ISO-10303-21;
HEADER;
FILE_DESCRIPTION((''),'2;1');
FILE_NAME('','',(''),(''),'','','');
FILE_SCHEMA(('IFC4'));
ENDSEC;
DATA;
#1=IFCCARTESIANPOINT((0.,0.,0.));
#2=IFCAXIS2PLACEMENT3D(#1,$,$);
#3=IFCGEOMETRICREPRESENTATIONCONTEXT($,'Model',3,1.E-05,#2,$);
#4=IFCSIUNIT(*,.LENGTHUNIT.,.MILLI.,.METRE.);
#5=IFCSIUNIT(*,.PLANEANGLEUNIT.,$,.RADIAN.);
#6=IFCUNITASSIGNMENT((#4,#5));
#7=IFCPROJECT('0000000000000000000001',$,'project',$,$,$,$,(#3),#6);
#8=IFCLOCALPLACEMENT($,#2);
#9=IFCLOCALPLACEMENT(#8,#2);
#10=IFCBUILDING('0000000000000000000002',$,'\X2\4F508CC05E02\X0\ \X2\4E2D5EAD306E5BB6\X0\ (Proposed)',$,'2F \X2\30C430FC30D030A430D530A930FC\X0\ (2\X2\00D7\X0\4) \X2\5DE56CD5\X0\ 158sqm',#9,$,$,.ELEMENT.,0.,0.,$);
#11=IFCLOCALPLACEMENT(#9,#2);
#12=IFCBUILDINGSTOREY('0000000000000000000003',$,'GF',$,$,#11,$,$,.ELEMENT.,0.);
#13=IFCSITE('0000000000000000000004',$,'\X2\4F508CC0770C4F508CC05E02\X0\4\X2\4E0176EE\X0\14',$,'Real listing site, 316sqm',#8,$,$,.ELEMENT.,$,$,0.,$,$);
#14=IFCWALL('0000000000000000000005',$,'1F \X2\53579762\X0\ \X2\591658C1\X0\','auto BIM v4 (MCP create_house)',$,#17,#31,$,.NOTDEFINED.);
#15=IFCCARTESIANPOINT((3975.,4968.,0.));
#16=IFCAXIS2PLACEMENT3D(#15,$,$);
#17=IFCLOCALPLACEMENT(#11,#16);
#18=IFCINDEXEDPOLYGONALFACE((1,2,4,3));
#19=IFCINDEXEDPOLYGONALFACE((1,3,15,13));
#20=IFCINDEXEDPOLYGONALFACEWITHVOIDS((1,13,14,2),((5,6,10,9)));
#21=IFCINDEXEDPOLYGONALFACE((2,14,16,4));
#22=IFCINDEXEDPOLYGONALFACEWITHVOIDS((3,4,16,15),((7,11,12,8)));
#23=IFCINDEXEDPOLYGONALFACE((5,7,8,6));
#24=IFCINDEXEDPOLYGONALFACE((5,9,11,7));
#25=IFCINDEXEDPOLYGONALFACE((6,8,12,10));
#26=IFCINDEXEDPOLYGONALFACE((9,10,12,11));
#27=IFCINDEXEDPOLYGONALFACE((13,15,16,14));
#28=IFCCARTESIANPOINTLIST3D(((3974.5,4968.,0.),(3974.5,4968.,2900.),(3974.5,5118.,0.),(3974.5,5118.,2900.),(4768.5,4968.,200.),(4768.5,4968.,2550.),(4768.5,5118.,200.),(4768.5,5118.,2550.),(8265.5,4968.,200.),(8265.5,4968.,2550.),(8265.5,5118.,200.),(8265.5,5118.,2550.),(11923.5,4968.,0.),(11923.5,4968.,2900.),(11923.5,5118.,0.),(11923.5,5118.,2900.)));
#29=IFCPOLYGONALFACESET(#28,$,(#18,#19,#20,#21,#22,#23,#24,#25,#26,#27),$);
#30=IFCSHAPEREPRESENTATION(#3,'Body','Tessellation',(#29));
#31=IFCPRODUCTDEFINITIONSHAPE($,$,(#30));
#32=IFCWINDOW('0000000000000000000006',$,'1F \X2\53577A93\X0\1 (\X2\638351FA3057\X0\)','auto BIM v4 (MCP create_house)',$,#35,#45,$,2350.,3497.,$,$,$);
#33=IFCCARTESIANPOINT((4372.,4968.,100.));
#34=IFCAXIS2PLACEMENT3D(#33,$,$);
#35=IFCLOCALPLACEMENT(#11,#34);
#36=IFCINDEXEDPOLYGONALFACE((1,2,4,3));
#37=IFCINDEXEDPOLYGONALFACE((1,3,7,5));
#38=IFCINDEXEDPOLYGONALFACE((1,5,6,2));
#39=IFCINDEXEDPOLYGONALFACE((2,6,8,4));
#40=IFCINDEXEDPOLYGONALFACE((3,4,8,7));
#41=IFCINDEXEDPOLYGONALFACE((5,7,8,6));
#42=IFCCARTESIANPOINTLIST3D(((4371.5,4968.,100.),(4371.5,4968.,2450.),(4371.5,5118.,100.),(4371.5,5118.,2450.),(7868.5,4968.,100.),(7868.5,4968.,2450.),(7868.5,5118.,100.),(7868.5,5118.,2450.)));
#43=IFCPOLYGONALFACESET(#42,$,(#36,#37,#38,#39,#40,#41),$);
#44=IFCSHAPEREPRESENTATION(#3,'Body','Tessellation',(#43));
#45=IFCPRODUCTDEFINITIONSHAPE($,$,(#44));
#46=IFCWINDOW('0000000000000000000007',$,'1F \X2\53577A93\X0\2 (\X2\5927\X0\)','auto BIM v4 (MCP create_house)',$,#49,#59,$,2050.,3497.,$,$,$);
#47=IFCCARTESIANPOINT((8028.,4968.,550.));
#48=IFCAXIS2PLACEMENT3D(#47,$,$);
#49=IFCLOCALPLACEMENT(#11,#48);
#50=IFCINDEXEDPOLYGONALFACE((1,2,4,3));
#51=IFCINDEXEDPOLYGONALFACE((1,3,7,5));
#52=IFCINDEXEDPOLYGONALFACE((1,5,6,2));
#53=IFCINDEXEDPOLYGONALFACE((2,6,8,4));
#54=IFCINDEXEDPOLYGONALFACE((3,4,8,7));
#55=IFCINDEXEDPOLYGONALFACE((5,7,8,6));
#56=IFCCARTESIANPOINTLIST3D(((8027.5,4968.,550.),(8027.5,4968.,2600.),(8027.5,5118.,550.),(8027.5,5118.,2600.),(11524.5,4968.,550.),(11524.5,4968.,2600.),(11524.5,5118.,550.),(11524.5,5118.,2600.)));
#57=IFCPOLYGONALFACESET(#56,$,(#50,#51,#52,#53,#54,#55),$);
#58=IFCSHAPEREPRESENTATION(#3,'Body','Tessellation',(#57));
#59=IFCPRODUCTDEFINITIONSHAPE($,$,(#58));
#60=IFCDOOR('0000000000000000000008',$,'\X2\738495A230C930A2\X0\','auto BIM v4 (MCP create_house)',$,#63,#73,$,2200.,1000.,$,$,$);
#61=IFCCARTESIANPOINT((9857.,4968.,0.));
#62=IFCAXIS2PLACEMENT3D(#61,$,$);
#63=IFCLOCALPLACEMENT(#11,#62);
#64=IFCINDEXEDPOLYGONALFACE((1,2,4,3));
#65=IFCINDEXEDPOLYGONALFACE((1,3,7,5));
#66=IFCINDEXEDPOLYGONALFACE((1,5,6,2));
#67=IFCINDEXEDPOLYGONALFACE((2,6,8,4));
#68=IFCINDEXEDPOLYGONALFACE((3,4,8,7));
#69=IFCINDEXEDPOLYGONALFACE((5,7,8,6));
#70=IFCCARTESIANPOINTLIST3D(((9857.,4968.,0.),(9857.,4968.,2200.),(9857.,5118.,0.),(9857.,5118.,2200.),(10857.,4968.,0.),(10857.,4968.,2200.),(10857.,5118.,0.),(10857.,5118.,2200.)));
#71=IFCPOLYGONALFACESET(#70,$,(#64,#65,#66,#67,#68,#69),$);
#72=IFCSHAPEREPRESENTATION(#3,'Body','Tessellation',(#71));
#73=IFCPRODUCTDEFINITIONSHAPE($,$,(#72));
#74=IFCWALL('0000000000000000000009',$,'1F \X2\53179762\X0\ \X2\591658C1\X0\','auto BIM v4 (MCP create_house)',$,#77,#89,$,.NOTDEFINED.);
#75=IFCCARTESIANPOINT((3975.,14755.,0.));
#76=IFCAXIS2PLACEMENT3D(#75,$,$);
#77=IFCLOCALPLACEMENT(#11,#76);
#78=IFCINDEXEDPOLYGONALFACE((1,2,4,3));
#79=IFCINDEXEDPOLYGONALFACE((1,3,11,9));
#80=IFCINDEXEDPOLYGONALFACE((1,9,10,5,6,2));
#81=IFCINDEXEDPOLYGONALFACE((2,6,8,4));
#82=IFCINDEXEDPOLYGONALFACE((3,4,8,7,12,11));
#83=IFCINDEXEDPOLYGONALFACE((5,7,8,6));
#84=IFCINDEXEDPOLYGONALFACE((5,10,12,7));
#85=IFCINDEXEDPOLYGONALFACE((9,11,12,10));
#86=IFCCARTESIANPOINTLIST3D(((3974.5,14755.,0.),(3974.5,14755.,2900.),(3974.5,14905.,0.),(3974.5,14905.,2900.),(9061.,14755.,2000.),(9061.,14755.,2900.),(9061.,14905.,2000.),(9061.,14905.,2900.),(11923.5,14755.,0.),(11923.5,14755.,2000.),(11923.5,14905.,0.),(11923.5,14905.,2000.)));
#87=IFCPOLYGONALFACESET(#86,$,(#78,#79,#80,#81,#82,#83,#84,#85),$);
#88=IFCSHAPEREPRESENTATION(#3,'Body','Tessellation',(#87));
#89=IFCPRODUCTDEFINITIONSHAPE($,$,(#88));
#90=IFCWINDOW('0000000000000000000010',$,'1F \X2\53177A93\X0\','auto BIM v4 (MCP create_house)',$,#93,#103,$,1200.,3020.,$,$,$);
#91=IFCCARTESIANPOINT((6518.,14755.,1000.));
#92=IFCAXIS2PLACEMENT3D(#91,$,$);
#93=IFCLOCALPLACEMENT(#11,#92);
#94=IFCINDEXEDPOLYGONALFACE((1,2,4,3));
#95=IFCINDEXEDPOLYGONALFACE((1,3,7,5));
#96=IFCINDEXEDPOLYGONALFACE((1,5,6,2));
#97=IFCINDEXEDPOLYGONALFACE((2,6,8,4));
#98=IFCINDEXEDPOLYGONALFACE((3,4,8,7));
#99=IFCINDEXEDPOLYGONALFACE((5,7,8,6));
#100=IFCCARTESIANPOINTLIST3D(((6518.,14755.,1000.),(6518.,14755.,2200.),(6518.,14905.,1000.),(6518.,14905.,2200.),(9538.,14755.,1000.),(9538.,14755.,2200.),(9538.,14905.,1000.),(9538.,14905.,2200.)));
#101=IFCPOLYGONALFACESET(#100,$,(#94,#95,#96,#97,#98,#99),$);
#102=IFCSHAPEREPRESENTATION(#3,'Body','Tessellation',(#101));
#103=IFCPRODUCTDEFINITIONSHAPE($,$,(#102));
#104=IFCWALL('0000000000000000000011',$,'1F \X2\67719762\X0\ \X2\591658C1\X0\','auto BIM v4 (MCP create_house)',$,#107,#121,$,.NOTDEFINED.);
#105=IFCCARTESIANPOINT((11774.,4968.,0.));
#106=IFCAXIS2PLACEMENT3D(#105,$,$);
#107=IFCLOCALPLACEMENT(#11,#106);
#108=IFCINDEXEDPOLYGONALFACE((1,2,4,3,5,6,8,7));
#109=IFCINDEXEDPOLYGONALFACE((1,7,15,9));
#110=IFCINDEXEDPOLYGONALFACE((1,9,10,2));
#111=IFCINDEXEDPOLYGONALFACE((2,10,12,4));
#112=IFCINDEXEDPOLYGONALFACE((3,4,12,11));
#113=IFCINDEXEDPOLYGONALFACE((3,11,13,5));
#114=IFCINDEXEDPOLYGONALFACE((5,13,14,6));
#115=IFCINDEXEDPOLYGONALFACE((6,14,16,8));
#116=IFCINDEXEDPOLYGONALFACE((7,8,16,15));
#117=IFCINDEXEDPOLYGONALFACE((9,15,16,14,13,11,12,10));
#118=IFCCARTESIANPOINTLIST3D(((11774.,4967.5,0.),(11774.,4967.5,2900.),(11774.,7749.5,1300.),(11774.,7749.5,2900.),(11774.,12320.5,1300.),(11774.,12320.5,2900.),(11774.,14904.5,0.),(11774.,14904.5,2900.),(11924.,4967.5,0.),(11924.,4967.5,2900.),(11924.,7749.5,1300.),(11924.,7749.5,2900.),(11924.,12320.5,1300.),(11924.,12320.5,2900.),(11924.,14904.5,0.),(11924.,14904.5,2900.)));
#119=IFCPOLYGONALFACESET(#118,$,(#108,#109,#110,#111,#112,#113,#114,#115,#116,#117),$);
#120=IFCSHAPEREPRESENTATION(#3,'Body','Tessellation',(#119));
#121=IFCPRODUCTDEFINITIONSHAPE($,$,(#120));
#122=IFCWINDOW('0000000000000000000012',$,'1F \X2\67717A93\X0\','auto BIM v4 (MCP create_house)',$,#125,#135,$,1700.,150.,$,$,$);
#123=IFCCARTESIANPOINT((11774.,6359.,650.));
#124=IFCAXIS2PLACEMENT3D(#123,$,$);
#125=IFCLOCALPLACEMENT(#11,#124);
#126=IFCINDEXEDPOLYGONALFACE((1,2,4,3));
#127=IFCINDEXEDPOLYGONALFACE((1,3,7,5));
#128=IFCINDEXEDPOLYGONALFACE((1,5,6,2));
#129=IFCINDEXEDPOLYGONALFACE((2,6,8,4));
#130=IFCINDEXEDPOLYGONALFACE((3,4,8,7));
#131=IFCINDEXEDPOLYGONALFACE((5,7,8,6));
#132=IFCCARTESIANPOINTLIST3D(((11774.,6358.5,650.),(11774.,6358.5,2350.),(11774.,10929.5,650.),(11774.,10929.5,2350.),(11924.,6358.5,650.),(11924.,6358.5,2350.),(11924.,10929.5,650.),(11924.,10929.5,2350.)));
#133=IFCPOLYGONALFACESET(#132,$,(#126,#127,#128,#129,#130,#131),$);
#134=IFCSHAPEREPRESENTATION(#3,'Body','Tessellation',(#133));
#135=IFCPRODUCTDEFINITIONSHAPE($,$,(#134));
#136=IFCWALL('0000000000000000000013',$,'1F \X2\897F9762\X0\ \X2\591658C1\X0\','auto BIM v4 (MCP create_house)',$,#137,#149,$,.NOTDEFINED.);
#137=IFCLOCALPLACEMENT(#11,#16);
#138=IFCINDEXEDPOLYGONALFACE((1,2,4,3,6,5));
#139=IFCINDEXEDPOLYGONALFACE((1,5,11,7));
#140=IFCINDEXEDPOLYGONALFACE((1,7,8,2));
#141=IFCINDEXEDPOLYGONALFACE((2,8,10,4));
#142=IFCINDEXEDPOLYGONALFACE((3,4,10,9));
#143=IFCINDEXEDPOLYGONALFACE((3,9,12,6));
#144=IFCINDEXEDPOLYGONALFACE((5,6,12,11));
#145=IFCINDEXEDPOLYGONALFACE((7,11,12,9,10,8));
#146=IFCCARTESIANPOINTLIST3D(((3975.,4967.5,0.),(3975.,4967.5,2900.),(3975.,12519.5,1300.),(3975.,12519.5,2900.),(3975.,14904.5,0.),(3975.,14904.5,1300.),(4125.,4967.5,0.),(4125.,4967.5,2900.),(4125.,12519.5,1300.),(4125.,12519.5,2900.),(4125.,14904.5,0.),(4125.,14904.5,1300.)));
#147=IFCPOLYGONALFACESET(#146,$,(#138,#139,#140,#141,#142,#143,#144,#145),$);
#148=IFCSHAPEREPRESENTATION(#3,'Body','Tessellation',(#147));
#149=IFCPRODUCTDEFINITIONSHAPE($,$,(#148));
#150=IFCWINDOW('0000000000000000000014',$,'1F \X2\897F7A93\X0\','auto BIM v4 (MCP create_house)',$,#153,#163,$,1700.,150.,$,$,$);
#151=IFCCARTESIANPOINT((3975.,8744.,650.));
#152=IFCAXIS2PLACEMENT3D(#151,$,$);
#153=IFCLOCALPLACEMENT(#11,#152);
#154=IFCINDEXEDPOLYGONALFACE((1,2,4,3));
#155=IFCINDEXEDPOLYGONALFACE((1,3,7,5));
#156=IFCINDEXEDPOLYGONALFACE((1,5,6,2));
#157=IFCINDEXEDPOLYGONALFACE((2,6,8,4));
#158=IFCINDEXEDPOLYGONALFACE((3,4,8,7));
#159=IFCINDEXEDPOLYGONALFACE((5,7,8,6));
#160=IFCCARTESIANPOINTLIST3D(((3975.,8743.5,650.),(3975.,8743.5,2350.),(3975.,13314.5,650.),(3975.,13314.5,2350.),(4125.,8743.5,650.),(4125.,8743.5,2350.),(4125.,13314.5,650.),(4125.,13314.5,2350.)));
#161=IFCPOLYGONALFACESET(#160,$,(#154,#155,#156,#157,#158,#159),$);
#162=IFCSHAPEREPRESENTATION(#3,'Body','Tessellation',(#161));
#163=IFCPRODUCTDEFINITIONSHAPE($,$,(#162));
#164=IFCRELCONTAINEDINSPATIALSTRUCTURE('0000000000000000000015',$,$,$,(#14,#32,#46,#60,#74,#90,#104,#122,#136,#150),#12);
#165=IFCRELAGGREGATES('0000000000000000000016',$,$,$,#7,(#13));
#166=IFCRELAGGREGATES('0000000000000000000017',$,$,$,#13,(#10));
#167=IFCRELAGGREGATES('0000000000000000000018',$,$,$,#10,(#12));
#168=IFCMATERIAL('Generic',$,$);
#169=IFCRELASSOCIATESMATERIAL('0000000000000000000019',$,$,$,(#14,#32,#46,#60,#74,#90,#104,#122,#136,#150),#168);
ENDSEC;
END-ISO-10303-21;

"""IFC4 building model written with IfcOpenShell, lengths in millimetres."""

from ifc_helpers import new_model, si_unit, frame, frame_2d, origin, place, context, project, spatial, rectangle, extrude, material, element, fill, save


model = new_model("IFC4")

# Units and contexts
model_context = context("Model", 3, precision=1e-05, world=origin())
ifc_project = project(units=[si_unit("LENGTHUNIT", "METRE", prefix="MILLI"), si_unit("PLANEANGLEUNIT", "RADIAN")], contexts=[model_context])

# Site, building, storey
site_placement = place(None, origin())
site = spatial("IfcSite", under=ifc_project, at=site_placement, Name="佐賀県佐賀市4丁目14", ObjectType="Real listing site, 316sqm", CompositionType="ELEMENT", RefElevation=0.0)
building_placement = place(site_placement, origin())
building = spatial("IfcBuilding", under=site, at=building_placement, Name="佐賀市 中庭の家 (Proposed)", ObjectType="2F ツーバイフォー (2×4) 工法 158sqm", CompositionType="ELEMENT", ElevationOfRefHeight=0.0, ElevationOfTerrain=0.0)
storey_placement = place(building_placement, origin())
storey = spatial("IfcBuildingStorey", under=building, at=storey_placement, Name="GF", CompositionType="ELEMENT", Elevation=0.0)

# Shared definitions
ifc_material = material(Name="Generic")

# Wall, openings, windows, door
wall_1_placement = place(storey_placement, frame((3975.0, 4968.0, 0.0)))
wall_1 = element("IfcWall", 1, at=wall_1_placement, inside=storey, material=ifc_material, Name="1F 南面 外壁", Description="auto BIM v4 (MCP create_house)", PredefinedType="NOTDEFINED", context=model_context, shape_type="SweptSolid", body=[
    extrude(rectangle(XDim=7949.0, YDim=150.0, at=frame_2d((3974.0, 75.0))), frame((3975.0, 4968.0, 0.0)), (0.0, 0.0, 1.0), 2900.0),
])
opening_1_placement = place(storey_placement, frame((4372.0, 4968.0, 100.0)))
opening_1 = element("IfcOpeningElement", 2, at=opening_1_placement, cuts=wall_1, PredefinedType="NOTDEFINED", context=model_context, shape_type="SweptSolid", body=[
    extrude(rectangle(XDim=3497.0, YDim=150.0, at=frame_2d((1748.0, 75.0))), frame((4372.0, 4968.0, 100.0)), (0.0, 0.0, 1.0), 2350.0),
])
opening_2_placement = place(storey_placement, frame((8028.0, 4968.0, 550.0)))
opening_2 = element("IfcOpeningElement", 3, at=opening_2_placement, cuts=wall_1, PredefinedType="NOTDEFINED", context=model_context, shape_type="SweptSolid", body=[
    extrude(rectangle(XDim=3497.0, YDim=150.0, at=frame_2d((1748.0, 75.0))), frame((8028.0, 4968.0, 550.0)), (0.0, 0.0, 1.0), 2050.0),
])
opening_3_placement = place(storey_placement, frame((9857.0, 4968.0, 0.0)))
opening_3 = element("IfcOpeningElement", 4, at=opening_3_placement, cuts=wall_1, PredefinedType="NOTDEFINED", context=model_context, shape_type="SweptSolid", body=[
    extrude(rectangle(XDim=1000.0, YDim=150.0, at=frame_2d((500.0, 75.0))), frame((9857.0, 4968.0, 0.0)), (0.0, 0.0, 1.0), 2200.0),
])
window_1_placement = place(storey_placement, frame((4372.0, 4968.0, 100.0)))
window_1 = element("IfcWindow", 5, at=window_1_placement, inside=storey, material=ifc_material, Name="1F 南窓1 (掃出し)", Description="auto BIM v4 (MCP create_house)", OverallHeight=2350.0, OverallWidth=3497.0, context=model_context, shape_type="SweptSolid", body=[
    extrude(rectangle(XDim=3497.0, YDim=150.0, at=frame_2d((1748.0, 75.0))), frame((4372.0, 4968.0, 100.0)), (0.0, 0.0, 1.0), 2350.0),
])
fill(opening_1, window_1)
window_2_placement = place(storey_placement, frame((8028.0, 4968.0, 550.0)))
window_2 = element("IfcWindow", 6, at=window_2_placement, inside=storey, material=ifc_material, Name="1F 南窓2 (大)", Description="auto BIM v4 (MCP create_house)", OverallHeight=2050.0, OverallWidth=3497.0, context=model_context, shape_type="SweptSolid", body=[
    extrude(rectangle(XDim=3497.0, YDim=150.0, at=frame_2d((1748.0, 75.0))), frame((8028.0, 4968.0, 550.0)), (0.0, 0.0, 1.0), 2050.0),
])
fill(opening_2, window_2)
door_1_placement = place(storey_placement, frame((9857.0, 4968.0, 0.0)))
door_1 = element("IfcDoor", 7, at=door_1_placement, inside=storey, material=ifc_material, Name="玄関ドア", Description="auto BIM v4 (MCP create_house)", OverallHeight=2200.0, OverallWidth=1000.0, context=model_context, shape_type="SweptSolid", body=[
    extrude(rectangle(XDim=1000.0, YDim=150.0, at=frame_2d((500.0, 75.0))), frame((9857.0, 4968.0, 0.0)), (0.0, 0.0, 1.0), 2200.0),
])
fill(opening_3, door_1)

# Walls, openings, windows
wall_2_placement = place(storey_placement, frame((3975.0, 14755.0, 0.0)))
wall_2 = element("IfcWall", 8, at=wall_2_placement, inside=storey, material=ifc_material, Name="1F 北面 外壁", Description="auto BIM v4 (MCP create_house)", PredefinedType="NOTDEFINED", context=model_context, shape_type="SweptSolid", body=[
    extrude(rectangle(XDim=7949.0, YDim=150.0, at=frame_2d((3974.0, 75.0))), frame((3975.0, 14755.0, 0.0)), (0.0, 0.0, 1.0), 2900.0),
])
opening_4_placement = place(storey_placement, frame((6518.0, 14755.0, 1000.0)))
opening_4 = element("IfcOpeningElement", 9, at=opening_4_placement, cuts=wall_2, PredefinedType="NOTDEFINED", context=model_context, shape_type="SweptSolid", body=[
    extrude(rectangle(XDim=3020.0, YDim=150.0, at=frame_2d((1510.0, 75.0))), frame((6518.0, 14755.0, 1000.0)), (0.0, 0.0, 1.0), 1200.0),
])
window_3_placement = place(storey_placement, frame((6518.0, 14755.0, 1000.0)))
window_3 = element("IfcWindow", 10, at=window_3_placement, inside=storey, material=ifc_material, Name="1F 北窓", Description="auto BIM v4 (MCP create_house)", OverallHeight=1200.0, OverallWidth=3020.0, context=model_context, shape_type="SweptSolid", body=[
    extrude(rectangle(XDim=3020.0, YDim=150.0, at=frame_2d((1510.0, 75.0))), frame((6518.0, 14755.0, 1000.0)), (0.0, 0.0, 1.0), 1200.0),
])
fill(opening_4, window_3)
wall_3_placement = place(storey_placement, frame((11774.0, 4968.0, 0.0)))
wall_3 = element("IfcWall", 11, at=wall_3_placement, inside=storey, material=ifc_material, Name="1F 東面 外壁", Description="auto BIM v4 (MCP create_house)", PredefinedType="NOTDEFINED", context=model_context, shape_type="SweptSolid", body=[
    extrude(rectangle(XDim=150.0, YDim=9937.0, at=frame_2d((75.0, 4968.0))), frame((11774.0, 4968.0, 0.0)), (0.0, 0.0, 1.0), 2900.0),
])
opening_5_placement = place(storey_placement, frame((11774.0, 6359.0, 650.0)))
opening_5 = element("IfcOpeningElement", 12, at=opening_5_placement, cuts=wall_3, PredefinedType="NOTDEFINED", context=model_context, shape_type="SweptSolid", body=[
    extrude(rectangle(XDim=150.0, YDim=4571.0, at=frame_2d((75.0, 2285.0))), frame((11774.0, 6359.0, 650.0)), (0.0, 0.0, 1.0), 1700.0),
])
window_4_placement = place(storey_placement, frame((11774.0, 6359.0, 650.0)))
window_4 = element("IfcWindow", 13, at=window_4_placement, inside=storey, material=ifc_material, Name="1F 東窓", Description="auto BIM v4 (MCP create_house)", OverallHeight=1700.0, OverallWidth=150.0, context=model_context, shape_type="SweptSolid", body=[
    extrude(rectangle(XDim=150.0, YDim=4571.0, at=frame_2d((75.0, 2285.0))), frame((11774.0, 6359.0, 650.0)), (0.0, 0.0, 1.0), 1700.0),
])
fill(opening_5, window_4)
wall_4_placement = place(storey_placement, frame((3975.0, 4968.0, 0.0)))
wall_4 = element("IfcWall", 14, at=wall_4_placement, inside=storey, material=ifc_material, Name="1F 西面 外壁", Description="auto BIM v4 (MCP create_house)", PredefinedType="NOTDEFINED", context=model_context, shape_type="SweptSolid", body=[
    extrude(rectangle(XDim=150.0, YDim=9937.0, at=frame_2d((75.0, 4968.0))), frame((3975.0, 4968.0, 0.0)), (0.0, 0.0, 1.0), 2900.0),
])
opening_6_placement = place(storey_placement, frame((3975.0, 8744.0, 650.0)))
opening_6 = element("IfcOpeningElement", 15, at=opening_6_placement, cuts=wall_4, PredefinedType="NOTDEFINED", context=model_context, shape_type="SweptSolid", body=[
    extrude(rectangle(XDim=150.0, YDim=4571.0, at=frame_2d((75.0, 2285.0))), frame((3975.0, 8744.0, 650.0)), (0.0, 0.0, 1.0), 1700.0),
])
window_5_placement = place(storey_placement, frame((3975.0, 8744.0, 650.0)))
window_5 = element("IfcWindow", 16, at=window_5_placement, inside=storey, material=ifc_material, Name="1F 西窓", Description="auto BIM v4 (MCP create_house)", OverallHeight=1700.0, OverallWidth=150.0, context=model_context, shape_type="SweptSolid", body=[
    extrude(rectangle(XDim=150.0, YDim=4571.0, at=frame_2d((75.0, 2285.0))), frame((3975.0, 8744.0, 650.0)), (0.0, 0.0, 1.0), 1700.0),
])
fill(opening_6, window_5)

save(model, "model.ifc")
